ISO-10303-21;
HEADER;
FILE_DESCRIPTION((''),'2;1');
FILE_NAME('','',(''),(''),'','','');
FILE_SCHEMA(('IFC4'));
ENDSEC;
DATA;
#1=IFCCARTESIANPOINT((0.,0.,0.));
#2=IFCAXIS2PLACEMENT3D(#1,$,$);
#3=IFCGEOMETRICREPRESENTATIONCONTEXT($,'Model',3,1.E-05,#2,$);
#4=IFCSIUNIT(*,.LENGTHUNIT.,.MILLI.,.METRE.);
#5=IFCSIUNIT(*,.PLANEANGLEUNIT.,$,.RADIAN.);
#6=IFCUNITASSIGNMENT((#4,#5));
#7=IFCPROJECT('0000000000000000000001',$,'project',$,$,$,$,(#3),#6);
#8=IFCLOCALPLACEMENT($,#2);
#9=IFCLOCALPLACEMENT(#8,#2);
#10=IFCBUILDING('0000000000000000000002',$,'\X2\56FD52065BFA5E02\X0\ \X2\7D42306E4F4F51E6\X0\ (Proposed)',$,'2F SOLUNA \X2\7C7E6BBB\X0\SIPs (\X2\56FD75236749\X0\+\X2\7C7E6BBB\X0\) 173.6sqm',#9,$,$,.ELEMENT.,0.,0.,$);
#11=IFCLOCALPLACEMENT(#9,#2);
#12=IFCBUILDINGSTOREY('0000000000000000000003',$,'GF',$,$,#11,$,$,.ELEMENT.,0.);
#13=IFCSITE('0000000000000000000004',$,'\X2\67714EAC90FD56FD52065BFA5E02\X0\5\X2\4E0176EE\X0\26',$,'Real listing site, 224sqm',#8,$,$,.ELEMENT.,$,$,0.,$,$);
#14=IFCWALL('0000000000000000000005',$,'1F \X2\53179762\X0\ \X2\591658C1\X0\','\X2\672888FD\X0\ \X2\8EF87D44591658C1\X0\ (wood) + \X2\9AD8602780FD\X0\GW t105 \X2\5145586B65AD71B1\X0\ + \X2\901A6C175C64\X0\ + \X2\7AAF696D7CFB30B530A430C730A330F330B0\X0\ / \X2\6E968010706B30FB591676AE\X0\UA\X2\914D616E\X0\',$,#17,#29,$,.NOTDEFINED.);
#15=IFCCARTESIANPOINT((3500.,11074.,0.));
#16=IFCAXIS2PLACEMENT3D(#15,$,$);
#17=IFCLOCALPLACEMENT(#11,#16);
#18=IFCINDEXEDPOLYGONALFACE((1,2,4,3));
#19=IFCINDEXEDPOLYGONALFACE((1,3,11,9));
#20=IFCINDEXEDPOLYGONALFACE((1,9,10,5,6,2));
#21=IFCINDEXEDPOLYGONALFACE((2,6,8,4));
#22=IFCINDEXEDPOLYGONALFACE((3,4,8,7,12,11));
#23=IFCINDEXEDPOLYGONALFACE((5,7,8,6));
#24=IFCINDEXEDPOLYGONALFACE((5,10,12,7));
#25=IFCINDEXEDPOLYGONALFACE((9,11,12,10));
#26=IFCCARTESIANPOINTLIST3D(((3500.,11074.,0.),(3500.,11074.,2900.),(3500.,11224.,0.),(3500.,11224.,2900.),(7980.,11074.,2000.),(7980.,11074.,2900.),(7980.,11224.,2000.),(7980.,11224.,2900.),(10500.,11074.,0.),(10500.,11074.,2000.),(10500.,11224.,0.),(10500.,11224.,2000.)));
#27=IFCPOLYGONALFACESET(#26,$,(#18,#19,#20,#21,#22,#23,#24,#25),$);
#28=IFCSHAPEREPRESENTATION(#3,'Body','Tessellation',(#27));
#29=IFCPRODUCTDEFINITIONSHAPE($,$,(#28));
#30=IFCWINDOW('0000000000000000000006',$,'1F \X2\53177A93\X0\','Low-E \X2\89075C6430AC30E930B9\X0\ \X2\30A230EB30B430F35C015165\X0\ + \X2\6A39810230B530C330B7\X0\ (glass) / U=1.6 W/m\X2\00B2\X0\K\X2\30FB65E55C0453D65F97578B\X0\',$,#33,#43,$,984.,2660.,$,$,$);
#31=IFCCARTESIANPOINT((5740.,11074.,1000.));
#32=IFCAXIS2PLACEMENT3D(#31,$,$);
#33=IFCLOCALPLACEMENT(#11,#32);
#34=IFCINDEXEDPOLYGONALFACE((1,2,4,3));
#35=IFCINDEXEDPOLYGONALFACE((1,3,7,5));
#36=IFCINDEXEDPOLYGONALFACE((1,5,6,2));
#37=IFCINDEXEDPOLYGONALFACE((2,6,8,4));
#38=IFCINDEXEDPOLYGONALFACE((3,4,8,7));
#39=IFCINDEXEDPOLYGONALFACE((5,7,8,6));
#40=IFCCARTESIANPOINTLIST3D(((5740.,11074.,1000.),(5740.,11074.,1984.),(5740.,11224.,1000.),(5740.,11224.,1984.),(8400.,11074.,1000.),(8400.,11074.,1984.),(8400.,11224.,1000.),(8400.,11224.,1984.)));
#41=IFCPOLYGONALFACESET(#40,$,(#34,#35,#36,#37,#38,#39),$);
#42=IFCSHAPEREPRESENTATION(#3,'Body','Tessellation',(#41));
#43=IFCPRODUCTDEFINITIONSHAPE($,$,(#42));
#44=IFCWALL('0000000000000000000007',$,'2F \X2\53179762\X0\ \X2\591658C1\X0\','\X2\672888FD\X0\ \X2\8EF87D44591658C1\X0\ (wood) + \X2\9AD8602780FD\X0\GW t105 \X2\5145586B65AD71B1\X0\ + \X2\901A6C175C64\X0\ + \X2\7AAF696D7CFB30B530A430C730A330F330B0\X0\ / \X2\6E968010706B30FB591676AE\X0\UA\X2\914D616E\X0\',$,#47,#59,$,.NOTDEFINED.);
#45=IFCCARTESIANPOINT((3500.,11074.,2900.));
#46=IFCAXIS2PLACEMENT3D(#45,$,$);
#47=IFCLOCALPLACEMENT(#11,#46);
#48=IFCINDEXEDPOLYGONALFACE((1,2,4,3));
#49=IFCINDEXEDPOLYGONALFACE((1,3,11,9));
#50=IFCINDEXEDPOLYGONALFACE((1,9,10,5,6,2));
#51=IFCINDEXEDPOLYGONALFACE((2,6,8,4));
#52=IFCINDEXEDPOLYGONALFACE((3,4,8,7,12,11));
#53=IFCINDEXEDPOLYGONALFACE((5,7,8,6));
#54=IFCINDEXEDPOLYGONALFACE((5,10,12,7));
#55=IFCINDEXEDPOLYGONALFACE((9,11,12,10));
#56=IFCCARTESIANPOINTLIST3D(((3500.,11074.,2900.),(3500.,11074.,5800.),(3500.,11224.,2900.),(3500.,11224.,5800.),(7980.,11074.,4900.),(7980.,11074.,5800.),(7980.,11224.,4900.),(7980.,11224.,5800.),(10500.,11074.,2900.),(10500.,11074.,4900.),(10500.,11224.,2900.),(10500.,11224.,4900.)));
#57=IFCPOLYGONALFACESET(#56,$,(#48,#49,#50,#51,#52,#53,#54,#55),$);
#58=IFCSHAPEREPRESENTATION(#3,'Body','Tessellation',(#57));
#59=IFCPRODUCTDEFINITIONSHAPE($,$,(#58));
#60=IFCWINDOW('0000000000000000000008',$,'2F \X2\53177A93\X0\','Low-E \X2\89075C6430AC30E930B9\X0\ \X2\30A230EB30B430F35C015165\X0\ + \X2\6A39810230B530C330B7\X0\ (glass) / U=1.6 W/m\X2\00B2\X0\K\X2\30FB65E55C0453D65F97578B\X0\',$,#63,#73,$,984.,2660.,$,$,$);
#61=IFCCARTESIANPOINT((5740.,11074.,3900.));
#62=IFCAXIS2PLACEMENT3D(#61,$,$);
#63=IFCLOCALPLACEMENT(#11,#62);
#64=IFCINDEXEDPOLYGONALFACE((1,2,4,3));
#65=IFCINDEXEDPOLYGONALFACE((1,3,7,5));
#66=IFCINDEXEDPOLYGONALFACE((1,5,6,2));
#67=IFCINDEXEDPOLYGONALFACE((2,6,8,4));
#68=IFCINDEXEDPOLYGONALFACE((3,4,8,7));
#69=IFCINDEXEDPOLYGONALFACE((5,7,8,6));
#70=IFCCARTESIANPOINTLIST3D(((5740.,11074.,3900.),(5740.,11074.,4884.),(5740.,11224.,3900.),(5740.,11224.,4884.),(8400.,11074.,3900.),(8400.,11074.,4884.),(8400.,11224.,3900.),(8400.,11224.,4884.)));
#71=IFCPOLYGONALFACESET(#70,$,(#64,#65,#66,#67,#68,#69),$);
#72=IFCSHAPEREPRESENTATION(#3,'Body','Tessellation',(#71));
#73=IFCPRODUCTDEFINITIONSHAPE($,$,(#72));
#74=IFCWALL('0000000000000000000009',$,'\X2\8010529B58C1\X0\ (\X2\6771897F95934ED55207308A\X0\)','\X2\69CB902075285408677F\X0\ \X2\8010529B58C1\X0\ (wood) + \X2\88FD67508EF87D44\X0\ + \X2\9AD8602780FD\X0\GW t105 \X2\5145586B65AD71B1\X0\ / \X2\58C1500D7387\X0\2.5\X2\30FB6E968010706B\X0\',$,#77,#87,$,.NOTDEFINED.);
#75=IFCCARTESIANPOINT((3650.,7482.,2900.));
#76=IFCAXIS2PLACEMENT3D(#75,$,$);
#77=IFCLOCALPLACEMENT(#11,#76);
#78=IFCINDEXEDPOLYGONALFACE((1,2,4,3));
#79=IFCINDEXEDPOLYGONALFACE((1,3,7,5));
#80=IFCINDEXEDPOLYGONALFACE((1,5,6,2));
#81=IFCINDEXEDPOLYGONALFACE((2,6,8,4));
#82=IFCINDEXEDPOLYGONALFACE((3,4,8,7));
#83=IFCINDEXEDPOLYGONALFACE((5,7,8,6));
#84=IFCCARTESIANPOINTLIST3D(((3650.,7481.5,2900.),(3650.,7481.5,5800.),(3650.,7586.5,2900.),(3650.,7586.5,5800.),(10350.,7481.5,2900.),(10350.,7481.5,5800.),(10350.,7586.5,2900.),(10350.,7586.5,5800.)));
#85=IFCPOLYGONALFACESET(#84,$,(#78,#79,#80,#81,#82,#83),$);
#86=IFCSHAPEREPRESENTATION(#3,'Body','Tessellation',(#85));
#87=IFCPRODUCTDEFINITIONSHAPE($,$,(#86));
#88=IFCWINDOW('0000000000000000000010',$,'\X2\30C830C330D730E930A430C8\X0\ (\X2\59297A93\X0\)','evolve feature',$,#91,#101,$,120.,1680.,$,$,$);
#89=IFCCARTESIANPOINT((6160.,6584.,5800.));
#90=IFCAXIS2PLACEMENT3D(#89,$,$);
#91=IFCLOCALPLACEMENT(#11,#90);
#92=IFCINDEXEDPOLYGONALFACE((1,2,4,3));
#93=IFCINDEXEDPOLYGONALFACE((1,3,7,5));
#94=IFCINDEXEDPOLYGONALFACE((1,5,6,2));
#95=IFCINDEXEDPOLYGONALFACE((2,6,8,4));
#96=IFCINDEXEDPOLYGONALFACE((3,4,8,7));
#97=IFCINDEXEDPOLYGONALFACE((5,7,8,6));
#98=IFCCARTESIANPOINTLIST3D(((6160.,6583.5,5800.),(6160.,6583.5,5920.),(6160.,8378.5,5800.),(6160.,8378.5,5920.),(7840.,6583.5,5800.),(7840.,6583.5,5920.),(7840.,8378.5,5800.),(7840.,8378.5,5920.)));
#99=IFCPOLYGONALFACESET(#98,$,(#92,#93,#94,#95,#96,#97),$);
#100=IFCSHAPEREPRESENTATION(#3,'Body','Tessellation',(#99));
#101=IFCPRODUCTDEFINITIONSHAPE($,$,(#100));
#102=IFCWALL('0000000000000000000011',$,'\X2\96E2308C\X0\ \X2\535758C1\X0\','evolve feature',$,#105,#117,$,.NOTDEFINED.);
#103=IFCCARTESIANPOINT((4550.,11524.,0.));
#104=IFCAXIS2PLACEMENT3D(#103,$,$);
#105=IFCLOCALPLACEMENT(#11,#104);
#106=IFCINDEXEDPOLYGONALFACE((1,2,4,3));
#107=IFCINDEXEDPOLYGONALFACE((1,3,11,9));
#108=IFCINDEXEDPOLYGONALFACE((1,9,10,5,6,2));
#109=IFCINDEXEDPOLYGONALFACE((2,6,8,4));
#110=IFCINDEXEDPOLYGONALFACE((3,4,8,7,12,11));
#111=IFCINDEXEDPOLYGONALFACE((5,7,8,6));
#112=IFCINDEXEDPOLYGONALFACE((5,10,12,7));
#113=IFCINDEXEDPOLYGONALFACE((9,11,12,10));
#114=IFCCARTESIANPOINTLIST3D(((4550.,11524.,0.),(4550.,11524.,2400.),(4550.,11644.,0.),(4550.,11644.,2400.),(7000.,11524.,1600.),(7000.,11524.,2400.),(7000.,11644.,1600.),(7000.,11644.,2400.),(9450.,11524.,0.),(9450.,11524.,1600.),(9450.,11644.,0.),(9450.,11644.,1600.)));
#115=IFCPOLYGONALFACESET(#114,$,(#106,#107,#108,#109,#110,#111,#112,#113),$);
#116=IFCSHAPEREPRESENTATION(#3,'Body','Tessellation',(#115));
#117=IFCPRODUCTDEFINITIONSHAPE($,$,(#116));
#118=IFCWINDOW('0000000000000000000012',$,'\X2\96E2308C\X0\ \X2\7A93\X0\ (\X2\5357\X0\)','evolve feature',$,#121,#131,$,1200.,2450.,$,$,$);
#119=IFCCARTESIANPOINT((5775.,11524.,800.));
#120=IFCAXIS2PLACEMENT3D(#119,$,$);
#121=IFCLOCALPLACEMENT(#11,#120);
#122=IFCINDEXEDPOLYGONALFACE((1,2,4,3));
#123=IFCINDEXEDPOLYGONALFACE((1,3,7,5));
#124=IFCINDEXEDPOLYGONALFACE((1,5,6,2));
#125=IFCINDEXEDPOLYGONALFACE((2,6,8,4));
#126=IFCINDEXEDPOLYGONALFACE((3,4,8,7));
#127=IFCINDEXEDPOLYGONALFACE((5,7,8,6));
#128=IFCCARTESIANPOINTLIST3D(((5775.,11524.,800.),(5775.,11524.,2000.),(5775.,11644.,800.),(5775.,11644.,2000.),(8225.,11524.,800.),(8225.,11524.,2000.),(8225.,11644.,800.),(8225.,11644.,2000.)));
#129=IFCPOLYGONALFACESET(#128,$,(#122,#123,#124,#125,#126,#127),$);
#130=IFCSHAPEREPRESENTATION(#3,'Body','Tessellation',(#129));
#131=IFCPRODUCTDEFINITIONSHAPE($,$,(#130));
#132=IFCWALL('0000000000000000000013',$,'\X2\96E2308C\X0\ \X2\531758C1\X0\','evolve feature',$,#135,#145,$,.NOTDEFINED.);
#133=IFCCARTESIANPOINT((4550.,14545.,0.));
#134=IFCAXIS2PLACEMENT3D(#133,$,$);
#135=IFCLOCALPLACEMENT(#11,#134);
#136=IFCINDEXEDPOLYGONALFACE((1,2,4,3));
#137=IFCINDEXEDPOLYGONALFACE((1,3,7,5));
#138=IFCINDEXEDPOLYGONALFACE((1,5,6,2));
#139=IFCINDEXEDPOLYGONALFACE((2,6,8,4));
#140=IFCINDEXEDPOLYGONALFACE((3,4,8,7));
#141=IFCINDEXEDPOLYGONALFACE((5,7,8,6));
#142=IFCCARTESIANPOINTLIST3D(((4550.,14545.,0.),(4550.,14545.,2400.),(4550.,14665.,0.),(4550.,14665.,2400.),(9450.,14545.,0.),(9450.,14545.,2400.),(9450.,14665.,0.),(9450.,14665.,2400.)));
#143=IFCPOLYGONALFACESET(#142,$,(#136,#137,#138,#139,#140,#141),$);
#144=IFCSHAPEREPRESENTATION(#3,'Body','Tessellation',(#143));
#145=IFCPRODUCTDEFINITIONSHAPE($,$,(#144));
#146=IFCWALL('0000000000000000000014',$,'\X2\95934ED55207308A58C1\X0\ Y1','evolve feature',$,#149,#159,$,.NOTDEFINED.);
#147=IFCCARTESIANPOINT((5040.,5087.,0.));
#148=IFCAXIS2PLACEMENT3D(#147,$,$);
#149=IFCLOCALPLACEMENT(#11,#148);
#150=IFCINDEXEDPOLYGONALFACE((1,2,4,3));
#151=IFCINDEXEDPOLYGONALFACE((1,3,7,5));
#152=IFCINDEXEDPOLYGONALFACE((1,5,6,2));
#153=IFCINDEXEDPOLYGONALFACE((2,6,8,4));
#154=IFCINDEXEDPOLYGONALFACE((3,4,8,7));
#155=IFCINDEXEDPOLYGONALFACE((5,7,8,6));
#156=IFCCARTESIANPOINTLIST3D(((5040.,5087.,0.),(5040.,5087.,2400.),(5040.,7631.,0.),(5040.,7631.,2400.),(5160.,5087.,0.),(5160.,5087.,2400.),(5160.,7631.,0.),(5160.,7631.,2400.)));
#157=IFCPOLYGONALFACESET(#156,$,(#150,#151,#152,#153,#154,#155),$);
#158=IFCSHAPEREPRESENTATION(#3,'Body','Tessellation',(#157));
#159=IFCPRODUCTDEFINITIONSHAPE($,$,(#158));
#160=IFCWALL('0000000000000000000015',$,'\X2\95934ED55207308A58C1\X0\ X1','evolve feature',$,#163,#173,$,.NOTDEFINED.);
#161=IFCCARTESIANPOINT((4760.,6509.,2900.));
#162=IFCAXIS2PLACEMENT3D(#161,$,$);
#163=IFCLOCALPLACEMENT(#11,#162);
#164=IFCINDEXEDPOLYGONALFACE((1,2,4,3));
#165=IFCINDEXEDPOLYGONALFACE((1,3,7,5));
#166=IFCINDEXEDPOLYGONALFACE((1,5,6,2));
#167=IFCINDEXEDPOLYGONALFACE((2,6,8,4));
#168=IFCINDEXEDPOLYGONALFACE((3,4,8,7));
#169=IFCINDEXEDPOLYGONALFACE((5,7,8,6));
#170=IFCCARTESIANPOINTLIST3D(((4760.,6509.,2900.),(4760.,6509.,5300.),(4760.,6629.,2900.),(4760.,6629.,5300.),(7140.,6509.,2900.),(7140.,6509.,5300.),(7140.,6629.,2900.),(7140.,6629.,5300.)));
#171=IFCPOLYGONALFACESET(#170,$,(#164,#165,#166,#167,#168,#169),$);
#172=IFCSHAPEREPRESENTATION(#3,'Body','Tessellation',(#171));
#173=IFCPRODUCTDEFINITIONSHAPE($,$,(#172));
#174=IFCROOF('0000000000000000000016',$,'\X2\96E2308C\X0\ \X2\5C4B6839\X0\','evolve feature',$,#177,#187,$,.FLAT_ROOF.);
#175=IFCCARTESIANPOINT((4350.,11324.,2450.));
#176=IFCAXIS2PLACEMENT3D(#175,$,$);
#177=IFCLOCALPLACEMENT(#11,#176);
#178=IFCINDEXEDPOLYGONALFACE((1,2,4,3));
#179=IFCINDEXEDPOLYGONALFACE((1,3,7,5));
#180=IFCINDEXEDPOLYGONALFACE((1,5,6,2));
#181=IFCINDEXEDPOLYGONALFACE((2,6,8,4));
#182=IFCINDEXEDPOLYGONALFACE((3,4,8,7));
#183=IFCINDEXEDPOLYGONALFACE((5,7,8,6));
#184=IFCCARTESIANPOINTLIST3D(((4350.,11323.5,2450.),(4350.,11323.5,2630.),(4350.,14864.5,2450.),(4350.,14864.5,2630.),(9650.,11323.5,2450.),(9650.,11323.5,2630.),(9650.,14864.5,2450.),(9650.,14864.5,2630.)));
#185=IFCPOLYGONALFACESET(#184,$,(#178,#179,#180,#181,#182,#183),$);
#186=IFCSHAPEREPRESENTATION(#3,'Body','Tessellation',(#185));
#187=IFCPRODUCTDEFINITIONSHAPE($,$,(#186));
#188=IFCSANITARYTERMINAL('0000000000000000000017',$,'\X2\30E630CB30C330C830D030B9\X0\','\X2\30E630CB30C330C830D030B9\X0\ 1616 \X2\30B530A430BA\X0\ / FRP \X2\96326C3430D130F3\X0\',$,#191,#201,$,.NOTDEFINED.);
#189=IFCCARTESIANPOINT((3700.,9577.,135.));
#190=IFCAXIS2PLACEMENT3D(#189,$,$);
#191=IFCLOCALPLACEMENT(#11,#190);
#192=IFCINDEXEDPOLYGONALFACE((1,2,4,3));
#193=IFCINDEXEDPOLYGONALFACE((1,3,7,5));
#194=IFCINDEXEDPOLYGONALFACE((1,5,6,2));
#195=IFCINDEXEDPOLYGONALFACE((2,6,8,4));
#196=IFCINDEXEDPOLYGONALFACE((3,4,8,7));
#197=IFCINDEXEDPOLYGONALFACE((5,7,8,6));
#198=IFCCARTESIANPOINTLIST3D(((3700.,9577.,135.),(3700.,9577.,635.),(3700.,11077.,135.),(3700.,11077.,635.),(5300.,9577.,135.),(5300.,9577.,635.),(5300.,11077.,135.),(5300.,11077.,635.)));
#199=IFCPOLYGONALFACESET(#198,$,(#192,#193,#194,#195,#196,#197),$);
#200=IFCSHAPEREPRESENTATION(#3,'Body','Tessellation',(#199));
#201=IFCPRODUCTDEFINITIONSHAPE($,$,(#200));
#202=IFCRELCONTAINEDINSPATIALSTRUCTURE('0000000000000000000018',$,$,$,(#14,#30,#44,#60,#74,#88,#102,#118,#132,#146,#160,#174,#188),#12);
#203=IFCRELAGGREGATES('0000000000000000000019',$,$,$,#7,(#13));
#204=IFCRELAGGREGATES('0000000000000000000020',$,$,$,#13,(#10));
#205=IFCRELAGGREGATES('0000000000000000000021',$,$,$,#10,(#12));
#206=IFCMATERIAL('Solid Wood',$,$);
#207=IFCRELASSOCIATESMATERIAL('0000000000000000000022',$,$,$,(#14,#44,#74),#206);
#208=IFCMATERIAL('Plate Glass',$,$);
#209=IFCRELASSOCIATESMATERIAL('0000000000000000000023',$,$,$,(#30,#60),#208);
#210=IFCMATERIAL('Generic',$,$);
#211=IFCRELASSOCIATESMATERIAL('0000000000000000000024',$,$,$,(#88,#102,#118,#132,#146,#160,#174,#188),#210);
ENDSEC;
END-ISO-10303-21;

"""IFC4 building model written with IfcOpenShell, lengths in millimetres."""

from ifc_helpers import new_model, si_unit, frame, frame_2d, origin, place, context, project, spatial, rectangle, extrude, material, element, fill, save


model = new_model("IFC4")

# Units and contexts
model_context = context("Model", 3, precision=1e-05, world=origin())
ifc_project = project(units=[si_unit("LENGTHUNIT", "METRE", prefix="MILLI"), si_unit("PLANEANGLEUNIT", "RADIAN")], contexts=[model_context])

# Site, building, storey
site_placement = place(None, origin())
site = spatial("IfcSite", under=ifc_project, at=site_placement, Name="東京都国分寺市5丁目26", ObjectType="Real listing site, 224sqm", CompositionType="ELEMENT", RefElevation=0.0)
building_placement = place(site_placement, origin())
building = spatial("IfcBuilding", under=site, at=building_placement, Name="国分寺市 終の住処 (Proposed)", ObjectType="2F SOLUNA 籾殻SIPs (国産杉+籾殻) 173.6sqm", CompositionType="ELEMENT", ElevationOfRefHeight=0.0, ElevationOfTerrain=0.0)
storey_placement = place(building_placement, origin())
storey = spatial("IfcBuildingStorey", under=building, at=storey_placement, Name="GF", CompositionType="ELEMENT", Elevation=0.0)

# Shared definitions
ifc_material_1 = material(Name="Generic")

# Wall, opening, window
ifc_material_2 = material(Name="Solid Wood")
wall_1_placement = place(storey_placement, frame((3500.0, 11074.0, 0.0)))
wall_1 = element("IfcWall", 1, at=wall_1_placement, inside=storey, material=ifc_material_2, Name="1F 北面 外壁", Description="木製 軸組外壁 (wood) + 高性能GW t105 充填断熱 + 通気層 + 窯業系サイディング / 準耐火・外皮UA配慮", PredefinedType="NOTDEFINED", context=model_context, shape_type="SweptSolid", body=[
    extrude(rectangle(XDim=7000.0, YDim=150.0, at=frame_2d((3500.0, 75.0))), frame((3500.0, 11074.0, 0.0)), (0.0, 0.0, 1.0), 2900.0),
])
opening_1_placement = place(storey_placement, frame((5740.0, 11074.0, 1000.0)))
opening_1 = element("IfcOpeningElement", 2, at=opening_1_placement, cuts=wall_1, PredefinedType="NOTDEFINED", context=model_context, shape_type="SweptSolid", body=[
    extrude(rectangle(XDim=2660.0, YDim=150.0, at=frame_2d((1330.0, 75.0))), frame((5740.0, 11074.0, 1000.0)), (0.0, 0.0, 1.0), 984.0),
])
ifc_material_3 = material(Name="Plate Glass")
window_1_placement = place(storey_placement, frame((5740.0, 11074.0, 1000.0)))
window_1 = element("IfcWindow", 3, at=window_1_placement, inside=storey, material=ifc_material_3, Name="1F 北窓", Description="Low-E 複層ガラス アルゴン封入 + 樹脂サッシ (glass) / U=1.6 W/m²K・日射取得型", OverallHeight=984.0, OverallWidth=2660.0, context=model_context, shape_type="SweptSolid", body=[
    extrude(rectangle(XDim=2660.0, YDim=150.0, at=frame_2d((1330.0, 75.0))), frame((5740.0, 11074.0, 1000.0)), (0.0, 0.0, 1.0), 984.0),
])
fill(opening_1, window_1)

# Wall, opening, window
wall_2_placement = place(storey_placement, frame((3500.0, 11074.0, 2900.0)))
wall_2 = element("IfcWall", 4, at=wall_2_placement, inside=storey, material=ifc_material_2, Name="2F 北面 外壁", Description="木製 軸組外壁 (wood) + 高性能GW t105 充填断熱 + 通気層 + 窯業系サイディング / 準耐火・外皮UA配慮", PredefinedType="NOTDEFINED", context=model_context, shape_type="SweptSolid", body=[
    extrude(rectangle(XDim=7000.0, YDim=150.0, at=frame_2d((3500.0, 75.0))), frame((3500.0, 11074.0, 2900.0)), (0.0, 0.0, 1.0), 2900.0),
])
opening_2_placement = place(storey_placement, frame((5740.0, 11074.0, 3900.0)))
opening_2 = element("IfcOpeningElement", 5, at=opening_2_placement, cuts=wall_2, PredefinedType="NOTDEFINED", context=model_context, shape_type="SweptSolid", body=[
    extrude(rectangle(XDim=2660.0, YDim=150.0, at=frame_2d((1330.0, 75.0))), frame((5740.0, 11074.0, 3900.0)), (0.0, 0.0, 1.0), 984.0),
])
window_2_placement = place(storey_placement, frame((5740.0, 11074.0, 3900.0)))
window_2 = element("IfcWindow", 6, at=window_2_placement, inside=storey, material=ifc_material_3, Name="2F 北窓", Description="Low-E 複層ガラス アルゴン封入 + 樹脂サッシ (glass) / U=1.6 W/m²K・日射取得型", OverallHeight=984.0, OverallWidth=2660.0, context=model_context, shape_type="SweptSolid", body=[
    extrude(rectangle(XDim=2660.0, YDim=150.0, at=frame_2d((1330.0, 75.0))), frame((5740.0, 11074.0, 3900.0)), (0.0, 0.0, 1.0), 984.0),
])
fill(opening_2, window_2)

# Wall
wall_3_placement = place(storey_placement, frame((3650.0, 7482.0, 2900.0)))
element("IfcWall", 7, at=wall_3_placement, inside=storey, material=ifc_material_2, Name="耐力壁 (東西間仕切り)", Description="構造用合板 耐力壁 (wood) + 製材軸組 + 高性能GW t105 充填断熱 / 壁倍率2.5・準耐火", PredefinedType="NOTDEFINED", context=model_context, shape_type="SweptSolid", body=[
    extrude(rectangle(XDim=6700.0, YDim=105.0, at=frame_2d((3350.0, 52.0))), frame((3650.0, 7482.0, 2900.0)), (0.0, 0.0, 1.0), 2900.0),
])

# Window
window_3_placement = place(storey_placement, frame((6160.0, 6584.0, 5800.0)))
element("IfcWindow", 8, at=window_3_placement, inside=storey, material=ifc_material_1, Name="トップライト (天窓)", Description="evolve feature", OverallHeight=120.0, OverallWidth=1680.0, context=model_context, shape_type="SweptSolid", body=[
    extrude(rectangle(XDim=1680.0, YDim=1795.0, at=frame_2d((840.0, 897.0))), frame((6160.0, 6584.0, 5800.0)), (0.0, 0.0, 1.0), 120.0),
])

# Wall, opening, window
wall_4_placement = place(storey_placement, frame((4550.0, 11524.0, 0.0)))
wall_4 = element("IfcWall", 9, at=wall_4_placement, inside=storey, material=ifc_material_1, Name="離れ 南壁", Description="evolve feature", PredefinedType="NOTDEFINED", context=model_context, shape_type="SweptSolid", body=[
    extrude(rectangle(XDim=4900.0, YDim=120.0, at=frame_2d((2450.0, 60.0))), frame((4550.0, 11524.0, 0.0)), (0.0, 0.0, 1.0), 2400.0),
])
opening_3_placement = place(storey_placement, frame((5775.0, 11524.0, 800.0)))
opening_3 = element("IfcOpeningElement", 10, at=opening_3_placement, cuts=wall_4, PredefinedType="NOTDEFINED", context=model_context, shape_type="SweptSolid", body=[
    extrude(rectangle(XDim=2450.0, YDim=120.0, at=frame_2d((1225.0, 60.0))), frame((5775.0, 11524.0, 800.0)), (0.0, 0.0, 1.0), 1200.0),
])
window_4_placement = place(storey_placement, frame((5775.0, 11524.0, 800.0)))
window_4 = element("IfcWindow", 11, at=window_4_placement, inside=storey, material=ifc_material_1, Name="離れ 窓 (南)", Description="evolve feature", OverallHeight=1200.0, OverallWidth=2450.0, context=model_context, shape_type="SweptSolid", body=[
    extrude(rectangle(XDim=2450.0, YDim=120.0, at=frame_2d((1225.0, 60.0))), frame((5775.0, 11524.0, 800.0)), (0.0, 0.0, 1.0), 1200.0),
])
fill(opening_3, window_4)

# Walls
wall_5_placement = place(storey_placement, frame((4550.0, 14545.0, 0.0)))
element("IfcWall", 12, at=wall_5_placement, inside=storey, material=ifc_material_1, Name="離れ 北壁", Description="evolve feature", PredefinedType="NOTDEFINED", context=model_context, shape_type="SweptSolid", body=[
    extrude(rectangle(XDim=4900.0, YDim=120.0, at=frame_2d((2450.0, 60.0))), frame((4550.0, 14545.0, 0.0)), (0.0, 0.0, 1.0), 2400.0),
])
wall_6_placement = place(storey_placement, frame((5040.0, 5087.0, 0.0)))
element("IfcWall", 13, at=wall_6_placement, inside=storey, material=ifc_material_1, Name="間仕切り壁 Y1", Description="evolve feature", PredefinedType="NOTDEFINED", context=model_context, shape_type="SweptSolid", body=[
    extrude(rectangle(XDim=120.0, YDim=2544.0, at=frame_2d((60.0, 1272.0))), frame((5040.0, 5087.0, 0.0)), (0.0, 0.0, 1.0), 2400.0),
])
wall_7_placement = place(storey_placement, frame((4760.0, 6509.0, 2900.0)))
element("IfcWall", 14, at=wall_7_placement, inside=storey, material=ifc_material_1, Name="間仕切り壁 X1", Description="evolve feature", PredefinedType="NOTDEFINED", context=model_context, shape_type="SweptSolid", body=[
    extrude(rectangle(XDim=2380.0, YDim=120.0, at=frame_2d((1190.0, 60.0))), frame((4760.0, 6509.0, 2900.0)), (0.0, 0.0, 1.0), 2400.0),
])

# Roof
roof_placement = place(storey_placement, frame((4350.0, 11324.0, 2450.0)))
element("IfcRoof", 15, at=roof_placement, inside=storey, material=ifc_material_1, Name="離れ 屋根", Description="evolve feature", PredefinedType="FLAT_ROOF", context=model_context, shape_type="SweptSolid", body=[
    extrude(rectangle(XDim=5300.0, YDim=3541.0, at=frame_2d((2650.0, 1770.0))), frame((4350.0, 11324.0, 2450.0)), (0.0, 0.0, 1.0), 180.0),
])

# Sanitary terminal
sanitary_terminal_1_placement = place(storey_placement, frame((3700.0, 9577.0, 135.0)))
element("IfcSanitaryTerminal", 16, at=sanitary_terminal_1_placement, inside=storey, material=ifc_material_1, Name="ユニットバス", Description="ユニットバス 1616 サイズ / FRP 防水パン", PredefinedType="NOTDEFINED", context=model_context, shape_type="SweptSolid", body=[
    extrude(rectangle(XDim=1600.0, YDim=1500.0, at=frame_2d((800.0, 750.0))), frame((3700.0, 9577.0, 135.0)), (0.0, 0.0, 1.0), 500.0),
])

save(model, "model.ifc")
